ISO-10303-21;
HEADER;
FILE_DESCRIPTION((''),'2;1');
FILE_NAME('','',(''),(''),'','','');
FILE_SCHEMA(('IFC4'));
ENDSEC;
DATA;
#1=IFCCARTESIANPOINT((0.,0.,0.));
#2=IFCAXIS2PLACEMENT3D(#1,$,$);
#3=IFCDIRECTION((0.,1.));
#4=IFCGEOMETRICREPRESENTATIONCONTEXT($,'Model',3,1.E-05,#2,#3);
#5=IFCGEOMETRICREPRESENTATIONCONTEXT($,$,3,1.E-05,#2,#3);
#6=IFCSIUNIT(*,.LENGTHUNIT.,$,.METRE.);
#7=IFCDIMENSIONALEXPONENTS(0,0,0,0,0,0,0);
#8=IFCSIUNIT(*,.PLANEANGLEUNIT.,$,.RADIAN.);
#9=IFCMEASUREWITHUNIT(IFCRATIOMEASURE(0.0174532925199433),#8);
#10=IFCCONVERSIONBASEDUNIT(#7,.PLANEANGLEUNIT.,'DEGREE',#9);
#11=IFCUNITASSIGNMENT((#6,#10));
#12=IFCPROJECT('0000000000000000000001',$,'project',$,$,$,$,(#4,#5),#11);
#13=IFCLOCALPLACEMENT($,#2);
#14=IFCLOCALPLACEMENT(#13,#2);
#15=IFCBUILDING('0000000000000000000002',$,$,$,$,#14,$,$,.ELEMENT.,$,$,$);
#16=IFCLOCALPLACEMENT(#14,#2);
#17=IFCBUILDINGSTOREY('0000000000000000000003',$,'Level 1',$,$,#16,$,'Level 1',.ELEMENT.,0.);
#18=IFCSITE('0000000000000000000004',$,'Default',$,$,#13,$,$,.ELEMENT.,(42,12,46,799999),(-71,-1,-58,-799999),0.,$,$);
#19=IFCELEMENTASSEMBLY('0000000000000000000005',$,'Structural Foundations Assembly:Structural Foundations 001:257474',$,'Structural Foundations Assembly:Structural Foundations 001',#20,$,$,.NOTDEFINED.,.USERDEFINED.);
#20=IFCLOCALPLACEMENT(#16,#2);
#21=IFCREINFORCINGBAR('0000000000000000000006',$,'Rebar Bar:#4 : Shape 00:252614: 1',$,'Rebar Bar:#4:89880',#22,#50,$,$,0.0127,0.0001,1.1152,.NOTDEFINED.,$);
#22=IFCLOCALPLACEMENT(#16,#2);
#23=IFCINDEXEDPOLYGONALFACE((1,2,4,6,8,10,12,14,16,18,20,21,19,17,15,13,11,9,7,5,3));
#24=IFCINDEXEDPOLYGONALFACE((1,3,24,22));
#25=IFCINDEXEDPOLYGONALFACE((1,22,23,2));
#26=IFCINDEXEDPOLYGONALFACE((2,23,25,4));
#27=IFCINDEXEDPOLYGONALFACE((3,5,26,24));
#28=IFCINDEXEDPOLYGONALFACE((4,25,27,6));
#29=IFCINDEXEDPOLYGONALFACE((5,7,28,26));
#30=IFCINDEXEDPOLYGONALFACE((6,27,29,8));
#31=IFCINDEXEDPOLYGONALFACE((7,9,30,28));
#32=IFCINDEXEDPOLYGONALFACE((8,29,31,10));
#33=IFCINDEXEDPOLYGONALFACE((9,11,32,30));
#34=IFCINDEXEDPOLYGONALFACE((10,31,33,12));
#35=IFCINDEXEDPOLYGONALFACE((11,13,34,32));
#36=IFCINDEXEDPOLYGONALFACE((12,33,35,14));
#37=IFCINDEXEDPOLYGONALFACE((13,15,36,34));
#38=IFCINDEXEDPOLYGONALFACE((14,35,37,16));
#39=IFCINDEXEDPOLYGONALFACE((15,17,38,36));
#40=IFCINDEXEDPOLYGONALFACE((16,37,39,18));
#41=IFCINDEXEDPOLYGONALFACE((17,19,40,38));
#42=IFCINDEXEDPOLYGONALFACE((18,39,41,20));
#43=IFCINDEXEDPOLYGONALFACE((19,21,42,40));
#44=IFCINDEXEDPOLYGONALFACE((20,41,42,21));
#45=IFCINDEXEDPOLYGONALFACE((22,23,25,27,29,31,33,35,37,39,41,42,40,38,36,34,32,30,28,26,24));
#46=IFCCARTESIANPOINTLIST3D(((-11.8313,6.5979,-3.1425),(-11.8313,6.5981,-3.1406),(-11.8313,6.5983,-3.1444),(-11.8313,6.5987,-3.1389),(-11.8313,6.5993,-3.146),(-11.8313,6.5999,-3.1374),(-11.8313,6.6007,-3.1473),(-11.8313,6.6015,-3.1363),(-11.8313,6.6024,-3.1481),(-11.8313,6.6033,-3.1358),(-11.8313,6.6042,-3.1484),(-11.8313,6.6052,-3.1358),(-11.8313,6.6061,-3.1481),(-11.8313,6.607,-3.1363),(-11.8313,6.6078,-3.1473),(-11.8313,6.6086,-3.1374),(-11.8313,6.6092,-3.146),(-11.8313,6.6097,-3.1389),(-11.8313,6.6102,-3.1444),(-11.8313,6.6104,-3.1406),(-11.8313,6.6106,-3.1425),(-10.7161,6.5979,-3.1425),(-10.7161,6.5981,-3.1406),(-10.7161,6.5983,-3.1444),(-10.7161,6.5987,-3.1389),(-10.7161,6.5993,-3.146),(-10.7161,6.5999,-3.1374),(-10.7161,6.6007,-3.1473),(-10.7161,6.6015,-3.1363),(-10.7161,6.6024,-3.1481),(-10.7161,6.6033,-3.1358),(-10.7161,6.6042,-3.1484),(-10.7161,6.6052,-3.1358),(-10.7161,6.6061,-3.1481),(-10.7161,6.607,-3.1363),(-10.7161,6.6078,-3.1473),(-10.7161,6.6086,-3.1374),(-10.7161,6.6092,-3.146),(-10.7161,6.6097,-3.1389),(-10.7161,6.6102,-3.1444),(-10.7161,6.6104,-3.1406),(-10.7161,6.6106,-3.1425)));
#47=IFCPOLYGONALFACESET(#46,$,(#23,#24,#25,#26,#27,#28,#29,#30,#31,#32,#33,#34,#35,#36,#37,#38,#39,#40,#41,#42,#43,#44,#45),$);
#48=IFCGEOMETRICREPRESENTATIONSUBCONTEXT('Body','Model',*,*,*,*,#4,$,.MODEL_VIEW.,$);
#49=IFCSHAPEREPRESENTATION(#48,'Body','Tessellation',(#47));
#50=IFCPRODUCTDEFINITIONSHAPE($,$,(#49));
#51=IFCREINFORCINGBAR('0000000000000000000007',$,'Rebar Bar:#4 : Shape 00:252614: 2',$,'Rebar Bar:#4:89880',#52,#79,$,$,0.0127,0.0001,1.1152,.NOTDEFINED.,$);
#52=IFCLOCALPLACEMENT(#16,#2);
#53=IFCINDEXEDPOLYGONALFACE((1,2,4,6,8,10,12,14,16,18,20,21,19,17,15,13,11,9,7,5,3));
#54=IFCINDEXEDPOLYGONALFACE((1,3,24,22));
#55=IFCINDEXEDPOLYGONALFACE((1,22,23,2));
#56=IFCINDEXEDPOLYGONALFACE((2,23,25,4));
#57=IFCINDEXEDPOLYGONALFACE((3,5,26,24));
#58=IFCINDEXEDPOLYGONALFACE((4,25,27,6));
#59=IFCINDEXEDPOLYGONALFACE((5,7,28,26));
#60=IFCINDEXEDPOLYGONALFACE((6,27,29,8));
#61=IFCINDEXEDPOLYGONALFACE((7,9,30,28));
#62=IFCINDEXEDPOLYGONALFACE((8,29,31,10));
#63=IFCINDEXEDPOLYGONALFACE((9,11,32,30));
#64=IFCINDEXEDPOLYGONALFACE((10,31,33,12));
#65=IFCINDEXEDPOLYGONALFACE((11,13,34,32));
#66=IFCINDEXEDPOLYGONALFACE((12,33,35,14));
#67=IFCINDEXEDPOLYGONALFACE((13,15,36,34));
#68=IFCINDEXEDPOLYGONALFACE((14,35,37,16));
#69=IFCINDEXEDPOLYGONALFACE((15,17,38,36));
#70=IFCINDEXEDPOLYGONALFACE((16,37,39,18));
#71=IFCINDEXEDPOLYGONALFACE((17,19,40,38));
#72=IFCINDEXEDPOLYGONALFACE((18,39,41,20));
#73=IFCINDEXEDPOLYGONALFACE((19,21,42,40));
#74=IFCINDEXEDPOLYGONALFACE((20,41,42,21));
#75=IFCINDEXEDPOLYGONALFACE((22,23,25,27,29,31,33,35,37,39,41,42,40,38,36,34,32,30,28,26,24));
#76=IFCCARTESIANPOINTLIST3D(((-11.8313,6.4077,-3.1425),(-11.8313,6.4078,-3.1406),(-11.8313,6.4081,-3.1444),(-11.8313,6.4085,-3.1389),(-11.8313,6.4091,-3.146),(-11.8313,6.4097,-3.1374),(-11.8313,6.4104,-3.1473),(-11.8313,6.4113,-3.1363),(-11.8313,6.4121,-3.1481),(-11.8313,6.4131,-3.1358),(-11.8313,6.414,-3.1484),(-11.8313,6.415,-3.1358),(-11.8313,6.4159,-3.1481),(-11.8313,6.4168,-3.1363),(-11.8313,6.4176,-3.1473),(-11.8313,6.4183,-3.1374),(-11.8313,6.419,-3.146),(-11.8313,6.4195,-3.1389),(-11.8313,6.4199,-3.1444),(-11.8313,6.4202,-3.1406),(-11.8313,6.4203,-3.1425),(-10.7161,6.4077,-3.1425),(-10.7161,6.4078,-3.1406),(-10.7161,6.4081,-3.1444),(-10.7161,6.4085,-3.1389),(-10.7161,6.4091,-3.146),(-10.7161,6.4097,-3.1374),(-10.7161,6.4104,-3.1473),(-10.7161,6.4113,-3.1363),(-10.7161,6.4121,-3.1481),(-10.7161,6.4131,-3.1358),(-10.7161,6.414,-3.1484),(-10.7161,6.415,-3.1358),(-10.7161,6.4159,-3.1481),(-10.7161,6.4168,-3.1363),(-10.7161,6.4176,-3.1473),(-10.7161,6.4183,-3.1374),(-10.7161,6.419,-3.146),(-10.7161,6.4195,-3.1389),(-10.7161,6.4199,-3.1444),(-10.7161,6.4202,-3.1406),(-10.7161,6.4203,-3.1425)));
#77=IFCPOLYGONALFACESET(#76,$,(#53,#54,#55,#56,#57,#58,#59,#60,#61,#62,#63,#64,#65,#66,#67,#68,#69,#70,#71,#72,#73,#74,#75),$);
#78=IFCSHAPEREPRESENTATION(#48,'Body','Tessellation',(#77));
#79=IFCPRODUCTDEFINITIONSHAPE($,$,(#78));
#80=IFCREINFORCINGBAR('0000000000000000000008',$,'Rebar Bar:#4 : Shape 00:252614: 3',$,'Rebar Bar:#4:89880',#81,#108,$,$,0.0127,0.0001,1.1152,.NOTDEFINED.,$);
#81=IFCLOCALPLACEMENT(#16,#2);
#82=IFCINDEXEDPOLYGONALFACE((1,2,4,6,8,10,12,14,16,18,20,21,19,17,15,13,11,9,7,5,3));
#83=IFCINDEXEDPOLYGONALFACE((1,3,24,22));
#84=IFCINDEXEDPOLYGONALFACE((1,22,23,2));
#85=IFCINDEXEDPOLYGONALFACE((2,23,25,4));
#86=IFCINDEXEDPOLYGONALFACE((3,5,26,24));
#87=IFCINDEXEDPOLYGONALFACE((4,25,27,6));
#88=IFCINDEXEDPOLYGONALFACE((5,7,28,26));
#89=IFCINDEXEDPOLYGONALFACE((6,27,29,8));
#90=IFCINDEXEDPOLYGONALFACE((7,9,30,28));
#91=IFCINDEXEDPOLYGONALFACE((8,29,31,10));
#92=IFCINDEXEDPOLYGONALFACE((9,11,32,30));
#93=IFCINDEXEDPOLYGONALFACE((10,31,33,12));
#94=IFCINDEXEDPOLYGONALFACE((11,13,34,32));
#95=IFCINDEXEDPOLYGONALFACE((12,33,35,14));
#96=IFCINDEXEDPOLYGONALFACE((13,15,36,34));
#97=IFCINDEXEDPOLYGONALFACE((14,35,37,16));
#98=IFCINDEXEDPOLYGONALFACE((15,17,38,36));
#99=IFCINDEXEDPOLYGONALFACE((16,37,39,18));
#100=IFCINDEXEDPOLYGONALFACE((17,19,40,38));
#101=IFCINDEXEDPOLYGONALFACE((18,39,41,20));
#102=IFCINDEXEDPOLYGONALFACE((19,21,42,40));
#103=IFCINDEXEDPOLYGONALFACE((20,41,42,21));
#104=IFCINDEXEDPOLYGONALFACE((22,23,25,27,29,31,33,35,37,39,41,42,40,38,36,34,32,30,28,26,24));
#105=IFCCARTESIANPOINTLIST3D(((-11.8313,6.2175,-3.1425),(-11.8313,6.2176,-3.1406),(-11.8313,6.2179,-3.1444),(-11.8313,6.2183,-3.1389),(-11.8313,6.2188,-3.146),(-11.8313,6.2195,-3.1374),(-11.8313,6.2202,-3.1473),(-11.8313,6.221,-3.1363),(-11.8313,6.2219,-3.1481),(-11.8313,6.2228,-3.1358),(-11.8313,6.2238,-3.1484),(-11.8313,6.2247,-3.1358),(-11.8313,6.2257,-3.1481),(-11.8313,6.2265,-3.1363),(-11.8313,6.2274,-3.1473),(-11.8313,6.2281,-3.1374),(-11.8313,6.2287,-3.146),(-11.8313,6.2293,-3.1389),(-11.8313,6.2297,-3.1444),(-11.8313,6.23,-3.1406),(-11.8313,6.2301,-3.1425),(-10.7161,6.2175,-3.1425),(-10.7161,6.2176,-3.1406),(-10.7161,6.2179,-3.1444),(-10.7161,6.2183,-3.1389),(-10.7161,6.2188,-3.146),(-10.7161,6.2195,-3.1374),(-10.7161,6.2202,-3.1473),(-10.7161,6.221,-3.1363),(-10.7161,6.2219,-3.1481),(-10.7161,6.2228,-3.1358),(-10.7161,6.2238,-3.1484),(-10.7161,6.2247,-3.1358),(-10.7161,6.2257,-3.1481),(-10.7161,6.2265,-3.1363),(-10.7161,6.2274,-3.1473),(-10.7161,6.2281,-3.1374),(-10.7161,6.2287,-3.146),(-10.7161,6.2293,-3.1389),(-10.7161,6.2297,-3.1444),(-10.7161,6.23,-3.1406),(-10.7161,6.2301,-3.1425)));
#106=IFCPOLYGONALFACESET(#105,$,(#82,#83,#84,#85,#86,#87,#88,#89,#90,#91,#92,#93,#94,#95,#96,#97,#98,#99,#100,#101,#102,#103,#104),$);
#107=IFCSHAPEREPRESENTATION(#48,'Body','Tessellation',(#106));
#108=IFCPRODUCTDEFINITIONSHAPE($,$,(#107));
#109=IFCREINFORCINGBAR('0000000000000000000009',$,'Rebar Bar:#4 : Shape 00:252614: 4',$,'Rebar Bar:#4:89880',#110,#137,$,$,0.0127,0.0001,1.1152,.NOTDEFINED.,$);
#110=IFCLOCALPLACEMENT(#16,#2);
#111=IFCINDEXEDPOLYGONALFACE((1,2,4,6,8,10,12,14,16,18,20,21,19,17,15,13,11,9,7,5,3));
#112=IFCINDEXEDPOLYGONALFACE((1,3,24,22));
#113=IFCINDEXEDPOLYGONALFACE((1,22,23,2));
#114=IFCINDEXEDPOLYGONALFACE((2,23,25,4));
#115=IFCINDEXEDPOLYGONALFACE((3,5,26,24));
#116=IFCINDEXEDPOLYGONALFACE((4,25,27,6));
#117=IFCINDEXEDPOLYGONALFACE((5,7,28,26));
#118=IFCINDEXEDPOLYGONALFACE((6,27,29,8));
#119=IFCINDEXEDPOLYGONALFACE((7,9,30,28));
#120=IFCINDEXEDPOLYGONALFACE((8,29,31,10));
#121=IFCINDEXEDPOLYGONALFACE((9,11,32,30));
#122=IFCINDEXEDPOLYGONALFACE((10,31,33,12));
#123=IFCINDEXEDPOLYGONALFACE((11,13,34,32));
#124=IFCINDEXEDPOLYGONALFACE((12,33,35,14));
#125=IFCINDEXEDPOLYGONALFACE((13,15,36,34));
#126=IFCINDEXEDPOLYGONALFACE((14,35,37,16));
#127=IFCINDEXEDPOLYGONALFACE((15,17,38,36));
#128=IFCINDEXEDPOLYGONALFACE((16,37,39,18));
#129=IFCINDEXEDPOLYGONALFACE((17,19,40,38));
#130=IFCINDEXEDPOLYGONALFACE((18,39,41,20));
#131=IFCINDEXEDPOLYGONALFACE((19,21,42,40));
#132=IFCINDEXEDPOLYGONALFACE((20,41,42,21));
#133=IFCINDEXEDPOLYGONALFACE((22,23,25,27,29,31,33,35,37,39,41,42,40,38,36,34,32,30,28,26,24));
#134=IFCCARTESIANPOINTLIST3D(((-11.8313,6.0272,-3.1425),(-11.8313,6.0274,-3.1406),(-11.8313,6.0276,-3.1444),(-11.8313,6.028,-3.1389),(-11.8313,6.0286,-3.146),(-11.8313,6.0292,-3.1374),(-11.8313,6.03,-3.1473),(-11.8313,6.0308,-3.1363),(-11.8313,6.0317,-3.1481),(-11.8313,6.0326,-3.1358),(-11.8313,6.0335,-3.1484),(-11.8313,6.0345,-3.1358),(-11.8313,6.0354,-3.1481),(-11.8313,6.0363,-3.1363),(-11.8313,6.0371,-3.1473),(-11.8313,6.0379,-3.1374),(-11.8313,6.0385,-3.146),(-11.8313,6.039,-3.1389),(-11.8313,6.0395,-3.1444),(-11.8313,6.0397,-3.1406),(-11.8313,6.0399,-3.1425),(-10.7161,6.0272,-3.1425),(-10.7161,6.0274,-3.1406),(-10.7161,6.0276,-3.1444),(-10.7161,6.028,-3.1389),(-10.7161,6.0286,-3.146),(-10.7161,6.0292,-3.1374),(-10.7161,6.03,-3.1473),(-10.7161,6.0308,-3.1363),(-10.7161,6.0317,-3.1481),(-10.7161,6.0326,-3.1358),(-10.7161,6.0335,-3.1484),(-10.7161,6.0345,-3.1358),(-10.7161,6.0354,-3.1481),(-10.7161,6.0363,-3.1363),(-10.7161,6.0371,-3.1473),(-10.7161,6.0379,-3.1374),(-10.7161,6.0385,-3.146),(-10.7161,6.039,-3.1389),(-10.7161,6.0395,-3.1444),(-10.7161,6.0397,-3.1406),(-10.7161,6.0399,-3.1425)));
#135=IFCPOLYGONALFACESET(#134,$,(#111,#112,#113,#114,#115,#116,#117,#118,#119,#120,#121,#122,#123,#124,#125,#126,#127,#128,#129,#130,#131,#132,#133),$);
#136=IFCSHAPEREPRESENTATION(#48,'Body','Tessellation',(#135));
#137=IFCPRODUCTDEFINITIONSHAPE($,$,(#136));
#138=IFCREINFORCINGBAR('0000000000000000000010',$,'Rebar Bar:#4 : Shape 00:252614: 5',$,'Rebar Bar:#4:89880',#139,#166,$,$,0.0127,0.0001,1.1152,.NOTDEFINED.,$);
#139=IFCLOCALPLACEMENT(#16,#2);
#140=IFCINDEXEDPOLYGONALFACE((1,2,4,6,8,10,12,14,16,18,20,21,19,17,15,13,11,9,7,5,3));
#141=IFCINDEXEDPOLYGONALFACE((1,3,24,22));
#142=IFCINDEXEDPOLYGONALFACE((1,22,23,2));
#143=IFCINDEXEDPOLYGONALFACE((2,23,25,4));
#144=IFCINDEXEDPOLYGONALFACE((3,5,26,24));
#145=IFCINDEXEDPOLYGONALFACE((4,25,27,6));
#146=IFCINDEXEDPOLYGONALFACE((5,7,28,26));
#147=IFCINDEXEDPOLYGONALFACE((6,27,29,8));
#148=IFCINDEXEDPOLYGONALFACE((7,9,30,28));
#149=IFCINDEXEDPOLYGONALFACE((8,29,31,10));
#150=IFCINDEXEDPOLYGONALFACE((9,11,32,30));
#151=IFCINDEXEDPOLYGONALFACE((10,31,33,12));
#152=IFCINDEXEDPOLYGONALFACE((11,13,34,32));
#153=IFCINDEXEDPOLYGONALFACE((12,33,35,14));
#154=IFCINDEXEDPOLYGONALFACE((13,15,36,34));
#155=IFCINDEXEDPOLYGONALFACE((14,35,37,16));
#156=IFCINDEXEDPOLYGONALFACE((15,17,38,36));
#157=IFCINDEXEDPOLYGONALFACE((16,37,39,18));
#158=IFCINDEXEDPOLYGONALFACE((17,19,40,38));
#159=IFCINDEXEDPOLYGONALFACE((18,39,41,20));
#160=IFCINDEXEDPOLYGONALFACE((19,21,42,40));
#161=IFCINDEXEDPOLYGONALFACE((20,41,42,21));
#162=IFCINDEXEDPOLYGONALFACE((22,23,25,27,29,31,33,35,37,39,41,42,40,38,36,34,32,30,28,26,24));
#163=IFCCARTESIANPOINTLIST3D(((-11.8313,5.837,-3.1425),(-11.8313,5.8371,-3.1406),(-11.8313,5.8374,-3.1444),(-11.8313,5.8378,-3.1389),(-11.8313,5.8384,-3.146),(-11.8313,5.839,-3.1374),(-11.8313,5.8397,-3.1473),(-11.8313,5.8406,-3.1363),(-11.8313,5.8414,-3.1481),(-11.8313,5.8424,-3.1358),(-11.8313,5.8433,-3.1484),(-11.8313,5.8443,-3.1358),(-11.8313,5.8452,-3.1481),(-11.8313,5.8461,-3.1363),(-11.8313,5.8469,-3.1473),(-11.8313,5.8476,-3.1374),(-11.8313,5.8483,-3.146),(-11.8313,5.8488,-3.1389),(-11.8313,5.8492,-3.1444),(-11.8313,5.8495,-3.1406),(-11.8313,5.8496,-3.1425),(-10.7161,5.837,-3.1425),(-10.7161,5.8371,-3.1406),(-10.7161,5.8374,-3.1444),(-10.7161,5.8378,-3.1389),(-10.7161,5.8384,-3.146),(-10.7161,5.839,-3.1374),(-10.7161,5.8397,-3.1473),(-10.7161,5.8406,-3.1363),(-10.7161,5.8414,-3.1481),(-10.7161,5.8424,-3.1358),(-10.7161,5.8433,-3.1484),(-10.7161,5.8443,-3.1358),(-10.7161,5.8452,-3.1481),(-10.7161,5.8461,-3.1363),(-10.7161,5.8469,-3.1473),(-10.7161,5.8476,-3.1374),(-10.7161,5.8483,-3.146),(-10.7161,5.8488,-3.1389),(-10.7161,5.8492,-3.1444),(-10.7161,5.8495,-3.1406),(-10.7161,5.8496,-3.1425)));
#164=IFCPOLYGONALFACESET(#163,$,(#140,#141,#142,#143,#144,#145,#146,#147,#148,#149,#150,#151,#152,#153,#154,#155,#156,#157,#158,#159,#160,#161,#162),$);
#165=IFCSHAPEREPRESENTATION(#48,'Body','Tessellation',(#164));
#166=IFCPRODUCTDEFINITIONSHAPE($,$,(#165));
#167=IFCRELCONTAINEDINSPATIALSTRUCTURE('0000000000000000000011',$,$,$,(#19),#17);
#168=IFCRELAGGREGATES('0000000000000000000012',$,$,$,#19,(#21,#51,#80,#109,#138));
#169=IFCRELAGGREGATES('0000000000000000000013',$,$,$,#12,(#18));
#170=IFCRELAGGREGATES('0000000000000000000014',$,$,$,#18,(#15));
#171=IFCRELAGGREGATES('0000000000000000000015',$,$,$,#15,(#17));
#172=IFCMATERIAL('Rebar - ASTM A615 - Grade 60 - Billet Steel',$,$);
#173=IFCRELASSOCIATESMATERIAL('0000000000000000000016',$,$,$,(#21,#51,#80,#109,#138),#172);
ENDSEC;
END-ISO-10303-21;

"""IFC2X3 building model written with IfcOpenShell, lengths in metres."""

from ifc_helpers import new_model, entity, si_unit, converted_unit, direction, origin, place, context, subcontext, project, spatial, material, element, aggregate, save


model = new_model("IFC2X3")

# Units and contexts
model_context = context("Model", 3, precision=1e-05, world=origin(), true_north=direction((0.0, 1.0)))
context_of_model = context(None, 3, precision=1e-05, world=origin(), true_north=direction((0.0, 1.0)))
body_context = subcontext(model_context, "Body", "Model", "MODEL_VIEW")
ifc_project = project(units=[si_unit("LENGTHUNIT", "METRE"), converted_unit("PLANEANGLEUNIT", "DEGREE", entity("IfcRatioMeasure", 0.0174532925199433), si_unit("PLANEANGLEUNIT", "RADIAN"), dimensions=[0, 0, 0, 0, 0, 0, 0])], contexts=[model_context, context_of_model])

# Site, building, storey
site_placement = place(None, origin())
site = spatial("IfcSite", under=ifc_project, at=site_placement, Name="Default", CompositionType="ELEMENT", RefLatitude=(42, 12, 46, 799999), RefLongitude=(-71, -1, -58, -799999), RefElevation=0.0)
building_placement = place(site_placement, origin())
building = spatial("IfcBuilding", under=site, at=building_placement, CompositionType="ELEMENT")
storey_placement = place(building_placement, origin())
storey = spatial("IfcBuildingStorey", under=building, at=storey_placement, Name="Level 1", LongName="Level 1", CompositionType="ELEMENT", Elevation=0.0)

# Element assembly, reinforcing bars
assembly_placement = place(storey_placement, origin())
assembly = element("IfcElementAssembly", 1, at=assembly_placement, inside=storey, Name="Structural Foundations Assembly:Structural Foundations 001:257474", ObjectType="Structural Foundations Assembly:Structural Foundations 001", AssemblyPlace="NOTDEFINED", PredefinedType="USERDEFINED")
ifc_material = material(Name="Rebar - ASTM A615 - Grade 60 - Billet Steel")
reinforcing_bar_1_placement = place(assembly_placement, origin())
reinforcing_bar_1 = element("IfcReinforcingBar", 2, at=reinforcing_bar_1_placement, material=ifc_material, Name="Rebar Bar:#4 : Shape 00:252614: 1", ObjectType="Rebar Bar:#4:89880", BarLength=1.1152, BarRole="NOTDEFINED", CrossSectionArea=0.0001, NominalDiameter=0.0127, context=body_context, shape_type="AdvancedSweptSolid", body=[
    entity("IfcSweptDiskSolid", entity("IfcCompositeCurve", [entity("IfcCompositeCurveSegment", "CONTINUOUS", True, entity("IfcPolyline", [entity("IfcCartesianPoint", [-10.7161, 6.6042, -3.142]), entity("IfcCartesianPoint", [-11.8313, 6.6042, -3.142])]))], False), 0.0063, None, 0.0, 1.0),
])
reinforcing_bar_2_placement = place(assembly_placement, origin())
reinforcing_bar_2 = element("IfcReinforcingBar", 3, at=reinforcing_bar_2_placement, material=ifc_material, Name="Rebar Bar:#4 : Shape 00:252614: 2", ObjectType="Rebar Bar:#4:89880", BarLength=1.1152, BarRole="NOTDEFINED", CrossSectionArea=0.0001, NominalDiameter=0.0127, context=body_context, shape_type="AdvancedSweptSolid", body=[
    entity("IfcSweptDiskSolid", entity("IfcCompositeCurve", [entity("IfcCompositeCurveSegment", "CONTINUOUS", True, entity("IfcPolyline", [entity("IfcCartesianPoint", [-10.7161, 6.414, -3.142]), entity("IfcCartesianPoint", [-11.8313, 6.414, -3.142])]))], False), 0.0063, None, 0.0, 1.0),
])
reinforcing_bar_3_placement = place(assembly_placement, origin())
reinforcing_bar_3 = element("IfcReinforcingBar", 4, at=reinforcing_bar_3_placement, material=ifc_material, Name="Rebar Bar:#4 : Shape 00:252614: 3", ObjectType="Rebar Bar:#4:89880", BarLength=1.1152, BarRole="NOTDEFINED", CrossSectionArea=0.0001, NominalDiameter=0.0127, context=body_context, shape_type="AdvancedSweptSolid", body=[
    entity("IfcSweptDiskSolid", entity("IfcCompositeCurve", [entity("IfcCompositeCurveSegment", "CONTINUOUS", True, entity("IfcPolyline", [entity("IfcCartesianPoint", [-10.7161, 6.2238, -3.142]), entity("IfcCartesianPoint", [-11.8313, 6.2238, -3.142])]))], False), 0.0063, None, 0.0, 1.0),
])
reinforcing_bar_4_placement = place(assembly_placement, origin())
reinforcing_bar_4 = element("IfcReinforcingBar", 5, at=reinforcing_bar_4_placement, material=ifc_material, Name="Rebar Bar:#4 : Shape 00:252614: 4", ObjectType="Rebar Bar:#4:89880", BarLength=1.1152, BarRole="NOTDEFINED", CrossSectionArea=0.0001, NominalDiameter=0.0127, context=body_context, shape_type="AdvancedSweptSolid", body=[
    entity("IfcSweptDiskSolid", entity("IfcCompositeCurve", [entity("IfcCompositeCurveSegment", "CONTINUOUS", True, entity("IfcPolyline", [entity("IfcCartesianPoint", [-10.7161, 6.0335, -3.142]), entity("IfcCartesianPoint", [-11.8313, 6.0335, -3.142])]))], False), 0.0063, None, 0.0, 1.0),
])
reinforcing_bar_5_placement = place(assembly_placement, origin())
reinforcing_bar_5 = element("IfcReinforcingBar", 6, at=reinforcing_bar_5_placement, material=ifc_material, Name="Rebar Bar:#4 : Shape 00:252614: 5", ObjectType="Rebar Bar:#4:89880", BarLength=1.1152, BarRole="NOTDEFINED", CrossSectionArea=0.0001, NominalDiameter=0.0127, context=body_context, shape_type="AdvancedSweptSolid", body=[
    entity("IfcSweptDiskSolid", entity("IfcCompositeCurve", [entity("IfcCompositeCurveSegment", "CONTINUOUS", True, entity("IfcPolyline", [entity("IfcCartesianPoint", [-10.7161, 5.8433, -3.142]), entity("IfcCartesianPoint", [-11.8313, 5.8433, -3.142])]))], False), 0.0063, None, 0.0, 1.0),
])
aggregate(assembly, [reinforcing_bar_1, reinforcing_bar_2, reinforcing_bar_3, reinforcing_bar_4, reinforcing_bar_5])

save(model, "model.ifc")
